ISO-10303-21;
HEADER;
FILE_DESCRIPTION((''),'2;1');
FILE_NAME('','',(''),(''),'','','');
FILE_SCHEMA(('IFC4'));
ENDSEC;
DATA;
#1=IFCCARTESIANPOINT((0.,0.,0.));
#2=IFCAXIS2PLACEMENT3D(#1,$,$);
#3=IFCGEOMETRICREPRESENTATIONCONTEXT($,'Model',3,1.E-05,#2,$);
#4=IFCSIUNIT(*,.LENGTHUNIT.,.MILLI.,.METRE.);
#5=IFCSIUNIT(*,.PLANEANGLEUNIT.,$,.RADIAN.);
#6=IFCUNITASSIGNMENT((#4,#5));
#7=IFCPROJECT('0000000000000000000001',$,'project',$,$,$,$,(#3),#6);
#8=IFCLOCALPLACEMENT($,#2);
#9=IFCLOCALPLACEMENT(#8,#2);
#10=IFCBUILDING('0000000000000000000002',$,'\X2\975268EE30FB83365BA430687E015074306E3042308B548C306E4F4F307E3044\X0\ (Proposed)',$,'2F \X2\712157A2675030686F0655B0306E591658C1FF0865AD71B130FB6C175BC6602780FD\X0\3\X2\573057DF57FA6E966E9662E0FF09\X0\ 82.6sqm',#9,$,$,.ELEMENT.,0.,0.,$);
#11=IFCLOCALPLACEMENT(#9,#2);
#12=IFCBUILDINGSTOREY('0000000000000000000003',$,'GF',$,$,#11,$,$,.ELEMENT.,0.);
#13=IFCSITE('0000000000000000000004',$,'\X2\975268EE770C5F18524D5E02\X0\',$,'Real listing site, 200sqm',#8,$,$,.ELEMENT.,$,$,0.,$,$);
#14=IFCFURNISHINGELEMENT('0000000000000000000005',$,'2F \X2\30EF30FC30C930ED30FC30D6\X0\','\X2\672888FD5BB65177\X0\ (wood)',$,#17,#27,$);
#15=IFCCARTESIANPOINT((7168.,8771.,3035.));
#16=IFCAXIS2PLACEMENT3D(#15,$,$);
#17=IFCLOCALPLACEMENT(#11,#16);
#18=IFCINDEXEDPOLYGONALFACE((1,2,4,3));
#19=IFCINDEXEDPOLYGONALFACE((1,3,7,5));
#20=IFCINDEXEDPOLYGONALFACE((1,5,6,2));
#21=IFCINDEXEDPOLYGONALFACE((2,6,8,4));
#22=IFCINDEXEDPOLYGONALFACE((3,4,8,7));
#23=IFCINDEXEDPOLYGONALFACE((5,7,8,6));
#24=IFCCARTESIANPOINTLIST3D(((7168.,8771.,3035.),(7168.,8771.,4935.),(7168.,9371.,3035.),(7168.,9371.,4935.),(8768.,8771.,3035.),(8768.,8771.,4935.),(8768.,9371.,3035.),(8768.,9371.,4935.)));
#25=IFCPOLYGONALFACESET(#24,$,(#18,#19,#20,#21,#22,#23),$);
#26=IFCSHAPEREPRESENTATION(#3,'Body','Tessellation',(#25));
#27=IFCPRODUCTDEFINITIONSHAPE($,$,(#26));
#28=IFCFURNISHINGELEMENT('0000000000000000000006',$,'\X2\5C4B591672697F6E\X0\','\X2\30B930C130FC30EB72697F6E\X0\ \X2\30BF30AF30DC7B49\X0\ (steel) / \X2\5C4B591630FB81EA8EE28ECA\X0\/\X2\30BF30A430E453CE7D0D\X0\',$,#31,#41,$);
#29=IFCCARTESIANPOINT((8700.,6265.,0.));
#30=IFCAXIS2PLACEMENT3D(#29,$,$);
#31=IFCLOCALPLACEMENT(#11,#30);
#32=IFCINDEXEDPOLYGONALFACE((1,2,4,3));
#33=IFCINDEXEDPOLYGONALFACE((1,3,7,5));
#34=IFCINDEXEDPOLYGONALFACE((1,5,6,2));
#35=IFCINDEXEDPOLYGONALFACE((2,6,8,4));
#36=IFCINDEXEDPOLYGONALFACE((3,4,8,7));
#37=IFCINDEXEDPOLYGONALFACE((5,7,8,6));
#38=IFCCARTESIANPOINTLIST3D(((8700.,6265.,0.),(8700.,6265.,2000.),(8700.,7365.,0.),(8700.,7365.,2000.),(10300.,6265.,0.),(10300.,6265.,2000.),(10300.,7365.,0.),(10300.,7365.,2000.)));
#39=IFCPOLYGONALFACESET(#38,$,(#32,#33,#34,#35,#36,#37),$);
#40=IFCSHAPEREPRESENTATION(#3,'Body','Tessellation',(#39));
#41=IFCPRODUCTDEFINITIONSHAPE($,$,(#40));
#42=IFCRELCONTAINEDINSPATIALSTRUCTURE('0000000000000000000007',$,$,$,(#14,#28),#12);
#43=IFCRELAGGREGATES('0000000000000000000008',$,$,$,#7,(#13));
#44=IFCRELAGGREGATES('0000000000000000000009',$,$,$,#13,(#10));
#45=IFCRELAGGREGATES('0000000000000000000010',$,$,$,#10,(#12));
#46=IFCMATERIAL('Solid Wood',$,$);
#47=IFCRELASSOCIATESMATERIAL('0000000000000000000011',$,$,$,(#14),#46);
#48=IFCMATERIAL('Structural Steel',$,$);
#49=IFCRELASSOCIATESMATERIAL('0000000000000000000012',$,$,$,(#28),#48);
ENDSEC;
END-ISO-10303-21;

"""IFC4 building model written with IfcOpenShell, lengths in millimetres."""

from ifc_helpers import new_model, si_unit, frame, frame_2d, origin, place, context, project, spatial, rectangle, extrude, material, element, save


model = new_model("IFC4")

# Units and contexts
model_context = context("Model", 3, precision=1e-05, world=origin())
ifc_project = project(units=[si_unit("LENGTHUNIT", "METRE", prefix="MILLI"), si_unit("PLANEANGLEUNIT", "RADIAN")], contexts=[model_context])

# Site, building, storey
site_placement = place(None, origin())
site = spatial("IfcSite", under=ifc_project, at=site_placement, Name="青森県弘前市", ObjectType="Real listing site, 200sqm", CompositionType="ELEMENT", RefElevation=0.0)
building_placement = place(site_placement, origin())
building = spatial("IfcBuilding", under=site, at=building_placement, Name="青森・茶室と縁側のある和の住まい (Proposed)", ObjectType="2F 無垢材と漆喰の外壁（断熱・気密性能3地域基準準拠） 82.6sqm", CompositionType="ELEMENT", ElevationOfRefHeight=0.0, ElevationOfTerrain=0.0)
storey_placement = place(building_placement, origin())
storey = spatial("IfcBuildingStorey", under=building, at=storey_placement, Name="GF", CompositionType="ELEMENT", Elevation=0.0)

# Shared definitions
ifc_material_1 = material(Name="Solid Wood")

# Shared definitions
ifc_material_2 = material(Name="Structural Steel")

# Furnishing elements
furnishing_1_placement = place(storey_placement, frame((7168.0, 8771.0, 3035.0)))
element("IfcFurnishingElement", 1, at=furnishing_1_placement, inside=storey, material=ifc_material_1, Name="2F ワードローブ", Description="木製家具 (wood)", context=model_context, shape_type="SweptSolid", body=[
    extrude(rectangle(XDim=1600.0, YDim=600.0, at=frame_2d((800.0, 300.0))), frame((7168.0, 8771.0, 3035.0)), (0.0, 0.0, 1.0), 1900.0),
])
furnishing_2_placement = place(storey_placement, frame((8700.0, 6265.0, 0.0)))
element("IfcFurnishingElement", 2, at=furnishing_2_placement, inside=storey, material=ifc_material_2, Name="屋外物置", Description="スチール物置 タクボ等 (steel) / 屋外・自転車/タイヤ収納", context=model_context, shape_type="SweptSolid", body=[
    extrude(rectangle(XDim=1600.0, YDim=1100.0, at=frame_2d((800.0, 550.0))), frame((8700.0, 6265.0, 0.0)), (0.0, 0.0, 1.0), 2000.0),
])

save(model, "model.ifc")
